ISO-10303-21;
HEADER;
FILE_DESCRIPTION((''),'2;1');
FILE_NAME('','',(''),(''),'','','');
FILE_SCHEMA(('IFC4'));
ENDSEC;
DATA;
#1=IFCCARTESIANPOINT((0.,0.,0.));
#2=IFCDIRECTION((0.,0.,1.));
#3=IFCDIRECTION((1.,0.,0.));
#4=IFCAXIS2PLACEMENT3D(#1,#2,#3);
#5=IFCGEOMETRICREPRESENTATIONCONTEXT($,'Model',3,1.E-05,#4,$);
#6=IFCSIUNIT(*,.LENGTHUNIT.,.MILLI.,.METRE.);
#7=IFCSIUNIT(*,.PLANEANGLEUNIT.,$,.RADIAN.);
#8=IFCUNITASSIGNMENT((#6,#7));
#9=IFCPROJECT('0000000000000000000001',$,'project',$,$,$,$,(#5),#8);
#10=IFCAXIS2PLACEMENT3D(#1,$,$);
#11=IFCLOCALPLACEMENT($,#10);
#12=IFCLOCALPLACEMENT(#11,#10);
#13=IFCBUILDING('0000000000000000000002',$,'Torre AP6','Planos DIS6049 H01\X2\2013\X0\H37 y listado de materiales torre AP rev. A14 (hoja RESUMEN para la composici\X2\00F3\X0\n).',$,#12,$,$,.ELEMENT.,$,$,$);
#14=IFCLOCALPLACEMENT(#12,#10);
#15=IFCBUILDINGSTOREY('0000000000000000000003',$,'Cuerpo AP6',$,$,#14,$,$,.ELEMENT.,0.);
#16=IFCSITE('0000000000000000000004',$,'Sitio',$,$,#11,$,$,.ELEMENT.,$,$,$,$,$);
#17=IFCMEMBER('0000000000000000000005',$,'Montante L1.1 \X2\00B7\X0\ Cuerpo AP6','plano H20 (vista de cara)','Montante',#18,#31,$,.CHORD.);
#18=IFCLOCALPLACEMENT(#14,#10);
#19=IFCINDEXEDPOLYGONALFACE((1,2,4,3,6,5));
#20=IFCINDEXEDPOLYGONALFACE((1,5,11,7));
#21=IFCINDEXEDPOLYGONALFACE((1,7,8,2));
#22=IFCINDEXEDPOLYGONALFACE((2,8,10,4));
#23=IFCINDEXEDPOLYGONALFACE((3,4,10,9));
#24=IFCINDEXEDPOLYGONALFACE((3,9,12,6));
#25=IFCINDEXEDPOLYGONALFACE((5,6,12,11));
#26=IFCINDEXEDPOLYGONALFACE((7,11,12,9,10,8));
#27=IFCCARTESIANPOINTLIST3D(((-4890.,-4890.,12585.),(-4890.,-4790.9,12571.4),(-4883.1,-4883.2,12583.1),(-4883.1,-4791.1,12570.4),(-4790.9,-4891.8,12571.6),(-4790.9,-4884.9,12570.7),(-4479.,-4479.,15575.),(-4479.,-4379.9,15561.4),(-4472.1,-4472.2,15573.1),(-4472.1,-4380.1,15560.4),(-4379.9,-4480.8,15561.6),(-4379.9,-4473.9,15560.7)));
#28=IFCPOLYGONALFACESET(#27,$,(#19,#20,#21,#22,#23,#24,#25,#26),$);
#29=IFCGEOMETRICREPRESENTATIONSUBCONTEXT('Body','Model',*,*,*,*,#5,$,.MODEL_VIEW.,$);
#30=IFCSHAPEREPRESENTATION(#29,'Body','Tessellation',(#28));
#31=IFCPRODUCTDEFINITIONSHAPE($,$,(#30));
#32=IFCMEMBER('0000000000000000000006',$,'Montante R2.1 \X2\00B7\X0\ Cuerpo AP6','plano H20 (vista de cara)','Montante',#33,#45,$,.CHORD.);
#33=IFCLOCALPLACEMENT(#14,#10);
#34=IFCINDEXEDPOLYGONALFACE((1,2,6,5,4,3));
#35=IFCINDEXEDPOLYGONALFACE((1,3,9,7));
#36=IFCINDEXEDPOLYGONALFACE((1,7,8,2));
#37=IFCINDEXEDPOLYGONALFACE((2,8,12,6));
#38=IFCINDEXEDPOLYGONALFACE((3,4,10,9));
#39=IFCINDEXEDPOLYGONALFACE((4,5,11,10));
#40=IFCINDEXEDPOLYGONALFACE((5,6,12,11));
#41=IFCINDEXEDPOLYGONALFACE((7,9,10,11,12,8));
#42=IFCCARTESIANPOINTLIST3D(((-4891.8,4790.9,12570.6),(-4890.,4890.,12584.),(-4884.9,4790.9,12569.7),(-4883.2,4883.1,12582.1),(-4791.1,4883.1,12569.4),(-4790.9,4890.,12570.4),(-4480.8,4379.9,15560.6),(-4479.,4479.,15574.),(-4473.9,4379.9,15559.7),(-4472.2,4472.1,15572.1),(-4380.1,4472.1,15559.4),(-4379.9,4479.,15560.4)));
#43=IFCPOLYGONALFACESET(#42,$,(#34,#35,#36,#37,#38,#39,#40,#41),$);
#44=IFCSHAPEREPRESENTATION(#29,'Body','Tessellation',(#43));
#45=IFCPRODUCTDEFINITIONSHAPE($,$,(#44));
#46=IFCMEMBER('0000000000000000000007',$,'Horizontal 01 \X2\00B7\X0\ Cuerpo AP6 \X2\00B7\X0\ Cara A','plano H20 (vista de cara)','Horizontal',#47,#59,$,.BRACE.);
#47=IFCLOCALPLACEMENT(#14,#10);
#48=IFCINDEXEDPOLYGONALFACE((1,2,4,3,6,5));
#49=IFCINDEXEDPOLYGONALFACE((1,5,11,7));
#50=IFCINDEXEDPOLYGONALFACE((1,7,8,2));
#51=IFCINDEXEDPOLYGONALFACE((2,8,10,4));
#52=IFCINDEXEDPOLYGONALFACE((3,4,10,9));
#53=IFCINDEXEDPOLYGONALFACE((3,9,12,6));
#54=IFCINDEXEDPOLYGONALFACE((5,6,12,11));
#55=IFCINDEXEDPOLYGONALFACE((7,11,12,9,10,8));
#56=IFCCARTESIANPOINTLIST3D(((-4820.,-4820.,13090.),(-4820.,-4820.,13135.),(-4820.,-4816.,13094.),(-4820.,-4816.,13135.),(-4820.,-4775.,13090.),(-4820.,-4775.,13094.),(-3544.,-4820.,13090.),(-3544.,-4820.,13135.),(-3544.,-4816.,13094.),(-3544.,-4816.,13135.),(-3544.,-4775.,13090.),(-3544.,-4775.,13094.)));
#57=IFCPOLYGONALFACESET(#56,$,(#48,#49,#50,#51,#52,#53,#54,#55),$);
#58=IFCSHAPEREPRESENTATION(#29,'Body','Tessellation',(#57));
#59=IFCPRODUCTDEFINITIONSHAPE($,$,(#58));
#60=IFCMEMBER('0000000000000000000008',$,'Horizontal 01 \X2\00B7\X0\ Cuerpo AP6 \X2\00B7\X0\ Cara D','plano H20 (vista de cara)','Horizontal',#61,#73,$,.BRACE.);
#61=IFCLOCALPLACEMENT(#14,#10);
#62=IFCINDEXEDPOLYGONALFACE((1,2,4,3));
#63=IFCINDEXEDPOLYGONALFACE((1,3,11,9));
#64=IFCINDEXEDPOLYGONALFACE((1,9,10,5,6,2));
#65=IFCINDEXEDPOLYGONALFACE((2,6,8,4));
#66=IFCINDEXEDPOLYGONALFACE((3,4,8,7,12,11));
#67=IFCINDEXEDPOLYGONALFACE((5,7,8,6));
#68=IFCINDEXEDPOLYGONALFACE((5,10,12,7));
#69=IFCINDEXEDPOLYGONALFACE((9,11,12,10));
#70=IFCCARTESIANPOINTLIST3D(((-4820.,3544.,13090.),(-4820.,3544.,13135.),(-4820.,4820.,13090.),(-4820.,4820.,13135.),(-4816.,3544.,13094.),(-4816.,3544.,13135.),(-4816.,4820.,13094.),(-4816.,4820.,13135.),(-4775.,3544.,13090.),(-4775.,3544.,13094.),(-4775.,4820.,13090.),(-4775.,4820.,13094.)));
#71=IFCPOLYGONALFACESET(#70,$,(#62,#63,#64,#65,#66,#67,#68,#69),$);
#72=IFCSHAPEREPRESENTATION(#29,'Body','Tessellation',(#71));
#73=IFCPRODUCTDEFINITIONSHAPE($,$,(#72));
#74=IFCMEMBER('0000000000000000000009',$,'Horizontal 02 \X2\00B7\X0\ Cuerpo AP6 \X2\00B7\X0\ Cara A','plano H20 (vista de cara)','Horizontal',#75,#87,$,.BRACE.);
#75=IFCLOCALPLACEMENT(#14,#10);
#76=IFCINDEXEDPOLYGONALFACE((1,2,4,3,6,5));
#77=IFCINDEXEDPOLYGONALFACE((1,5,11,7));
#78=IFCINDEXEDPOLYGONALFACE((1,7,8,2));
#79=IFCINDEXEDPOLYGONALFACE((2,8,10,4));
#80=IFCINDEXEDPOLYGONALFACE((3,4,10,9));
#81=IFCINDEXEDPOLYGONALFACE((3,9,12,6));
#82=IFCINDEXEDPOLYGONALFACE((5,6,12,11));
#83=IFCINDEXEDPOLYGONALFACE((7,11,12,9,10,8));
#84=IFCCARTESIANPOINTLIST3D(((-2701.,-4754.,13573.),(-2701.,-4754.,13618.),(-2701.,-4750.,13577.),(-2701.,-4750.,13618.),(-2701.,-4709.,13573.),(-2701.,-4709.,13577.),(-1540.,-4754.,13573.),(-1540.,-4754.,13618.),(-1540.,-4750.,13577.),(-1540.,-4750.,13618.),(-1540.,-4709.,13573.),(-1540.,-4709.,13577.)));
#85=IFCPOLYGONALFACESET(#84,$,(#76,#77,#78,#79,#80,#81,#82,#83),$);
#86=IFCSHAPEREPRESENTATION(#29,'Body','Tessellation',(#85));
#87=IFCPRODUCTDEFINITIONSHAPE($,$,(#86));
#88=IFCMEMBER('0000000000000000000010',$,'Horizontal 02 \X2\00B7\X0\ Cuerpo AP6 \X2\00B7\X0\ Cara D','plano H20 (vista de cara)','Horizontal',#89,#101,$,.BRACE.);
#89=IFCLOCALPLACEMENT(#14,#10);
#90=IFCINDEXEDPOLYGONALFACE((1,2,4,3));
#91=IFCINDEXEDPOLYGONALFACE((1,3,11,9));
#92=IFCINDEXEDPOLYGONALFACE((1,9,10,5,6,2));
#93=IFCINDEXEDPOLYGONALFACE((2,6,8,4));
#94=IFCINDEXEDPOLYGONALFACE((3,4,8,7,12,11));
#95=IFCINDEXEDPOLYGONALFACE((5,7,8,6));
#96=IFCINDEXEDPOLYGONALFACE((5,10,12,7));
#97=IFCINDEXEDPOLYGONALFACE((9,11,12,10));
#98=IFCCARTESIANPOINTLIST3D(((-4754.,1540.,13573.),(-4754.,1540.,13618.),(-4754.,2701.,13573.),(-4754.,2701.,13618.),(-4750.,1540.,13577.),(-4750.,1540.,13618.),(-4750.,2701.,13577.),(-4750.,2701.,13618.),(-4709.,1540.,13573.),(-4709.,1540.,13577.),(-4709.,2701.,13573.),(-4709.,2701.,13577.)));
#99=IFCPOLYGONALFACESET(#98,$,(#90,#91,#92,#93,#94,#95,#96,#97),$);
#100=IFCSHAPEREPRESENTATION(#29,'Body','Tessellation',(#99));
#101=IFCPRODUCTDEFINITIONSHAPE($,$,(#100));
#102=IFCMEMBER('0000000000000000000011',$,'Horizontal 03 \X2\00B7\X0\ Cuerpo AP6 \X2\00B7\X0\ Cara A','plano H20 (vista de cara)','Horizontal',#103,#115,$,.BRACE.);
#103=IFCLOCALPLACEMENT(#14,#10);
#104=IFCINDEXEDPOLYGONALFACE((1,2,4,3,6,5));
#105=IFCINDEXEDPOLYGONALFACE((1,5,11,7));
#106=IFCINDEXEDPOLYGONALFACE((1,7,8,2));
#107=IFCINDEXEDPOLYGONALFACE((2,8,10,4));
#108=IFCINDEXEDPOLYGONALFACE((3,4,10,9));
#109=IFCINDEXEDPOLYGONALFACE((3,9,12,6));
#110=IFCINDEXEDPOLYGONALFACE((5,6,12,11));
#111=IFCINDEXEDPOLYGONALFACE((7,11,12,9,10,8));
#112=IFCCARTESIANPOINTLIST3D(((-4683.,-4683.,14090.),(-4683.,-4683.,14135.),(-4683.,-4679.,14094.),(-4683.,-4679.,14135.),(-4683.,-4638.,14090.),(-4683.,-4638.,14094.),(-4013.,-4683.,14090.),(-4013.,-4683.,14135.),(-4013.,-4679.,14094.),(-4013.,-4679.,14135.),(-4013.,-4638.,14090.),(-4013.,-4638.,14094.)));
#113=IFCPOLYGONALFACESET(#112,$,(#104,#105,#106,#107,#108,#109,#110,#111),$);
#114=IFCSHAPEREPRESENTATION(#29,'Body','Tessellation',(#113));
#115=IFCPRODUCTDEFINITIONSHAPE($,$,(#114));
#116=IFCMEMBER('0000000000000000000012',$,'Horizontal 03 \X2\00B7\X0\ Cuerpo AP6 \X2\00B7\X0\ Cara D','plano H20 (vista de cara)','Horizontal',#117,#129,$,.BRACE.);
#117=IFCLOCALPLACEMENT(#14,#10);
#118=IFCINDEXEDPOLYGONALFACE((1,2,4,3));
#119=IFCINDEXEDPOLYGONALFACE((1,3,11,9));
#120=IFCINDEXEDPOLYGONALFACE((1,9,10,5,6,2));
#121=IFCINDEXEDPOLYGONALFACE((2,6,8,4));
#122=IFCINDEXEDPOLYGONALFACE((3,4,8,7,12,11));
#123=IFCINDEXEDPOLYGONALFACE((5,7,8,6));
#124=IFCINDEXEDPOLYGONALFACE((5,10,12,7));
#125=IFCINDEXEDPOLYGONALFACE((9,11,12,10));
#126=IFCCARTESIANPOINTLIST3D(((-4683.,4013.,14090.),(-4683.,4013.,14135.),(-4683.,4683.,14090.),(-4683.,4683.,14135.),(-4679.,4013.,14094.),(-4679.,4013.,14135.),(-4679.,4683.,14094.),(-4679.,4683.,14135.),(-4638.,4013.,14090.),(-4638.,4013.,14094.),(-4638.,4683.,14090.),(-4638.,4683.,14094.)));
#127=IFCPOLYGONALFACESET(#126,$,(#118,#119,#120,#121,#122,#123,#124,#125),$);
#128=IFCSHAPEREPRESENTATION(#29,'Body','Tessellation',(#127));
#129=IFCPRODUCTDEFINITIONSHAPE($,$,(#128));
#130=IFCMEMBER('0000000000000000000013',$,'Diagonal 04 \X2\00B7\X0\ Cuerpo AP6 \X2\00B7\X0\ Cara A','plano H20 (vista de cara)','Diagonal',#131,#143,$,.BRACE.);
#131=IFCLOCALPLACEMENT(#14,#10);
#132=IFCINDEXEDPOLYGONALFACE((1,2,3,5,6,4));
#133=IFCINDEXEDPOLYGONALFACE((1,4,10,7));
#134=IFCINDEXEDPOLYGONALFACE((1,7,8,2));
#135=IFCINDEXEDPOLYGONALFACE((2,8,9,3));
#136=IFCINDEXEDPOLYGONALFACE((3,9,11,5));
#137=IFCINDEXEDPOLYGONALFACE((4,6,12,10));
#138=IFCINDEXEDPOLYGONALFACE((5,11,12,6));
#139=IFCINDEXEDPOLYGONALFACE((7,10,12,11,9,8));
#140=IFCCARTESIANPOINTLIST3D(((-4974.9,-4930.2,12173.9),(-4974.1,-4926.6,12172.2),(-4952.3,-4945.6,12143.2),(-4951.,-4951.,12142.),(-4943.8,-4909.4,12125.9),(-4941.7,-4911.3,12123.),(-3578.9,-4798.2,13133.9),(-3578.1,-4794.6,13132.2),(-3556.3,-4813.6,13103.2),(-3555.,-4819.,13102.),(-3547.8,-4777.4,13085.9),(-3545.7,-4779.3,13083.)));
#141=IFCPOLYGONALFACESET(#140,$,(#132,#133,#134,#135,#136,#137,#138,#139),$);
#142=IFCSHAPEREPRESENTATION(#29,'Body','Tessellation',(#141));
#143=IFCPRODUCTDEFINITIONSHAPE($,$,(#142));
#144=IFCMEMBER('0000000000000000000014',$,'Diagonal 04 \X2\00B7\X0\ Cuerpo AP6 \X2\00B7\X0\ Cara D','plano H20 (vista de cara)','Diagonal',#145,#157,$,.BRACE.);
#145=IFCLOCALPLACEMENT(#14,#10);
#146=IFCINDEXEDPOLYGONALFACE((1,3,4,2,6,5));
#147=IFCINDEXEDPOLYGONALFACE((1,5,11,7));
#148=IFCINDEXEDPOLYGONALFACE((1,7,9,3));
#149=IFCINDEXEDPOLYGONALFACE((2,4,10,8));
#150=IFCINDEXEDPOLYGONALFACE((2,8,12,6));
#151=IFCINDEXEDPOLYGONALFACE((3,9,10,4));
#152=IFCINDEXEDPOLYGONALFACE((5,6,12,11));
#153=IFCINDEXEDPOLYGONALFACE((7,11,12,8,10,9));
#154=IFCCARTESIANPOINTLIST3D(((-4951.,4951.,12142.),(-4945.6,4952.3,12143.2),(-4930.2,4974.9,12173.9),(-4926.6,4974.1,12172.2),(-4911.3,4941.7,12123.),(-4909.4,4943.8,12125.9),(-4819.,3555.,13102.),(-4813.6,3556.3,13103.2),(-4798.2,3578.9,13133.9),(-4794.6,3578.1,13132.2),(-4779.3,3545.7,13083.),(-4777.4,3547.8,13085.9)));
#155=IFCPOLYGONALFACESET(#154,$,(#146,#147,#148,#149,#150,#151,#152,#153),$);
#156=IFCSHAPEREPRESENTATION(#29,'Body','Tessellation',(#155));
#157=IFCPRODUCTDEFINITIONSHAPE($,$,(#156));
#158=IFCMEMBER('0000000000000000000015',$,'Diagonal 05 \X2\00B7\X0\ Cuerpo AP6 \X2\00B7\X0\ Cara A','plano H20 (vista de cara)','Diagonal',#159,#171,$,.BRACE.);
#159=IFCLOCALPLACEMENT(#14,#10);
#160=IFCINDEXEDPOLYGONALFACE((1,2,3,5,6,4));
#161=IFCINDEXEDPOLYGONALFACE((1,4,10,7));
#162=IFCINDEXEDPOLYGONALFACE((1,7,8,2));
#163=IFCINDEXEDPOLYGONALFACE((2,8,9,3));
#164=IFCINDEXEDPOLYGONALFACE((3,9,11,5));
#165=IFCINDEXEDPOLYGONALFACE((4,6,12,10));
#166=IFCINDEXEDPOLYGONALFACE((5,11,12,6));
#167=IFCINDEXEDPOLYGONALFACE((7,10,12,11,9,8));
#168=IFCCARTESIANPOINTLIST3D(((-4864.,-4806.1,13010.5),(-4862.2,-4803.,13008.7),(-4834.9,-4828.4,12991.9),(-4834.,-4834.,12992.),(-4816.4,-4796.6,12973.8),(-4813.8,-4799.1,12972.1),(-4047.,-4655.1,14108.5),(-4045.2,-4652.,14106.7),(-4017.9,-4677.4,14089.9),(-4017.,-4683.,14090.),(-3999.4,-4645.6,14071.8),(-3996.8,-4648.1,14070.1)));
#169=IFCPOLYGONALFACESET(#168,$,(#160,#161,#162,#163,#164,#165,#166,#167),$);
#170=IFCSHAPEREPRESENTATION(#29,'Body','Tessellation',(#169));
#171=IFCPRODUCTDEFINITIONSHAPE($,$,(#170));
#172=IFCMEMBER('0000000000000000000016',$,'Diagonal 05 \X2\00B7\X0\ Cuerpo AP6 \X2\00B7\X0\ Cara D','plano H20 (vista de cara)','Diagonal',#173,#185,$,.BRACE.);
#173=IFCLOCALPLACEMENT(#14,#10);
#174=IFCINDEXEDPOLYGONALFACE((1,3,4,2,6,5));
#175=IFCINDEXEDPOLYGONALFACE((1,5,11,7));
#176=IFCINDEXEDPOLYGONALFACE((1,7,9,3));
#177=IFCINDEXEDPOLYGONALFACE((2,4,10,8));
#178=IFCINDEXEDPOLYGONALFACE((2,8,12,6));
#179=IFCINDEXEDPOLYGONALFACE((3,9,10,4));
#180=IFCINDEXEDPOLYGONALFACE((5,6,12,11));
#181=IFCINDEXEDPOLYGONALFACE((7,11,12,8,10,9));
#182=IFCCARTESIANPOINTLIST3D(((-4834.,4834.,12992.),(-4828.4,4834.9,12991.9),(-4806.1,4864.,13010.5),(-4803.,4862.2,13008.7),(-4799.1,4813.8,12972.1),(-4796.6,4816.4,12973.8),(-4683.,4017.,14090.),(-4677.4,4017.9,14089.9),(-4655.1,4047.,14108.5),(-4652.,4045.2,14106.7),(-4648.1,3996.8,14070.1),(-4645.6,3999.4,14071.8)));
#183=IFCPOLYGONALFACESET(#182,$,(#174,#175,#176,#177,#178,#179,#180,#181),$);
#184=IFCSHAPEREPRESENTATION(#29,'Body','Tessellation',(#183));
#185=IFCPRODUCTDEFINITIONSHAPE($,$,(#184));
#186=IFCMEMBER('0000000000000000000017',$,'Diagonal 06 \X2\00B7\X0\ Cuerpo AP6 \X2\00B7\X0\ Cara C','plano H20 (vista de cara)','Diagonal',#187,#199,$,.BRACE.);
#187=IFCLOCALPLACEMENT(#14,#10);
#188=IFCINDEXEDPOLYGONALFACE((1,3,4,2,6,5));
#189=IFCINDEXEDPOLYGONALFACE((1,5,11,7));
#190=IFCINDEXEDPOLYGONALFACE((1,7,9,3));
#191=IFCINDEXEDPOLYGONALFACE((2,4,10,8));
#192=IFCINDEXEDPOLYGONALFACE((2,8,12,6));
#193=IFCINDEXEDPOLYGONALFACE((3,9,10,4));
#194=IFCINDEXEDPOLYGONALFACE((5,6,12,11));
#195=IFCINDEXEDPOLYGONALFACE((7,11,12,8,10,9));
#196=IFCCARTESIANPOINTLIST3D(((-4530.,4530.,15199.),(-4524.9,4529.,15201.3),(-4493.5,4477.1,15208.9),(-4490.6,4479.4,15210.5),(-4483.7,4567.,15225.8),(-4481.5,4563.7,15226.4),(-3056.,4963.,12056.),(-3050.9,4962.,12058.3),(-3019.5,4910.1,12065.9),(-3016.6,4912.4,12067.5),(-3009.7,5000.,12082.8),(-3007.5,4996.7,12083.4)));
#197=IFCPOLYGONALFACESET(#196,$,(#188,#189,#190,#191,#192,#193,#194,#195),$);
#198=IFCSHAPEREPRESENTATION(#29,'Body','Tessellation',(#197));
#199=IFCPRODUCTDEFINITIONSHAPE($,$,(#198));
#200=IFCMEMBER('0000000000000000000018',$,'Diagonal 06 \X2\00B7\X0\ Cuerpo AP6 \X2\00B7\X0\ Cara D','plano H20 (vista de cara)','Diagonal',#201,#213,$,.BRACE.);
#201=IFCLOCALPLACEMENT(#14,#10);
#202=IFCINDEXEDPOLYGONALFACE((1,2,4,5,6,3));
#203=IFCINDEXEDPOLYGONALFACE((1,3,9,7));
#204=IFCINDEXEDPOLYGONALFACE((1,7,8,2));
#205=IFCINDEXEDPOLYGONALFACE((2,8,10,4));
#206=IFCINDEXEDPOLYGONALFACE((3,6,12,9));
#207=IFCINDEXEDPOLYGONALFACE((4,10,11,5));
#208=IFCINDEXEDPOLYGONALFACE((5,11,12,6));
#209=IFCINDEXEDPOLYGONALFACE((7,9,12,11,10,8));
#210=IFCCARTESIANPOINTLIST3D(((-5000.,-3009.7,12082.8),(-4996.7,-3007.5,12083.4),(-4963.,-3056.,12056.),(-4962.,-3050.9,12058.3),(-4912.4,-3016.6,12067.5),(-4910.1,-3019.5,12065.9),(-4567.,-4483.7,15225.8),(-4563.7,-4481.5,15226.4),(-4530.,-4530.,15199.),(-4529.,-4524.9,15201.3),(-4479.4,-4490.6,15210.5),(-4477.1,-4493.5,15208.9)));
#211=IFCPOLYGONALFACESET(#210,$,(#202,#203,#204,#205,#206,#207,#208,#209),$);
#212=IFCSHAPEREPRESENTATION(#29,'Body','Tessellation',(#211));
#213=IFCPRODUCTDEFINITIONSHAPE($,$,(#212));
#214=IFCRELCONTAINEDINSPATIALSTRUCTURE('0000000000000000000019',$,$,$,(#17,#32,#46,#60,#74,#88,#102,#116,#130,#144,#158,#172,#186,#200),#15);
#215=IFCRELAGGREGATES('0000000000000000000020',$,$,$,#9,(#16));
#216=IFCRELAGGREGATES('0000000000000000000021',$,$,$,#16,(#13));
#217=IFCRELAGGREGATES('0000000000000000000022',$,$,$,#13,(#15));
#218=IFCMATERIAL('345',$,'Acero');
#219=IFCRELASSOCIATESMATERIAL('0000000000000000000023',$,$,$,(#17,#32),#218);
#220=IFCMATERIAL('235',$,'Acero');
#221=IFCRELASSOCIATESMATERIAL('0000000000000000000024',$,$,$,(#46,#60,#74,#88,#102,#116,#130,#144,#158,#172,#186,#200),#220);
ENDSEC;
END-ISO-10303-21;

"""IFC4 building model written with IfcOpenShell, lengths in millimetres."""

from ifc_helpers import new_model, si_unit, frame, frame_2d, origin, origin_with_axes, place, context, subcontext, project, spatial, l_section, extrude, material, element, save


model = new_model("IFC4")

# Units and contexts
model_context = context("Model", 3, precision=1e-05, world=origin_with_axes())
body_context = subcontext(model_context, "Body", "Model", "MODEL_VIEW")
ifc_project = project(units=[si_unit("LENGTHUNIT", "METRE", prefix="MILLI"), si_unit("PLANEANGLEUNIT", "RADIAN")], contexts=[model_context])

# Site, building, storey
site_placement = place(None, origin())
site = spatial("IfcSite", under=ifc_project, at=site_placement, Name="Sitio", CompositionType="ELEMENT")
building_placement = place(site_placement, origin())
building = spatial("IfcBuilding", under=site, at=building_placement, Name="Torre AP6", Description="Planos DIS6049 H01–H37 y listado de materiales torre AP rev. A14 (hoja RESUMEN para la composición).", CompositionType="ELEMENT")
storey_placement = place(building_placement, origin())
storey = spatial("IfcBuildingStorey", under=building, at=storey_placement, Name="Cuerpo AP6", CompositionType="ELEMENT", Elevation=0.0)

# Members
ifc_material_1 = material(Name="345", Category="Acero")
for number, where, z_axis, x_axis, name in (
    (1, (-4890.0, -4890.0, 12585.0), (0.134932, 0.134932, 0.981624), (0.990855, -0.018375, -0.133675), "Montante L1.1 · Cuerpo AP6"),
    (2, (-4890.0, 4890.0, 12584.0), (0.134932, -0.134932, 0.981624), (-0.018375, -0.990855, -0.133675), "Montante R2.1 · Cuerpo AP6"),
):
    element("IfcMember", number, at=place(storey_placement, frame(where, z_axis=z_axis, x_axis=x_axis)), inside=storey, material=ifc_material_1, Name=name, Description="plano H20 (vista de cara)", ObjectType="Montante", PredefinedType="CHORD", context=body_context, shape_type="SweptSolid", body=[
        extrude(l_section(Depth=100.0, Width=100.0, Thickness=7.0, at=frame_2d((50.0, 50.0))), None, (0.0, 0.0, 1.0), 3046.0),
    ])
ifc_material_2 = material(Name="235", Category="Acero")
for number, where, z_axis, x_axis, name in (
    (3, (-4820.0, -4820.0, 13090.0), (1.0, 0.0, 0.0), (0.0, 1.0, 0.0), "Horizontal 01 · Cuerpo AP6 · Cara A"),
    (4, (-4820.0, 4820.0, 13090.0), (0.0, -1.0, 0.0), (1.0, 0.0, 0.0), "Horizontal 01 · Cuerpo AP6 · Cara D"),
):
    element("IfcMember", number, at=place(storey_placement, frame(where, z_axis=z_axis, x_axis=x_axis)), inside=storey, material=ifc_material_2, Name=name, Description="plano H20 (vista de cara)", ObjectType="Horizontal", PredefinedType="BRACE", context=body_context, shape_type="SweptSolid", body=[
        extrude(l_section(Depth=45.0, Width=45.0, Thickness=4.0, at=frame_2d((22.5, 22.5))), None, (0.0, 0.0, 1.0), 1276.0),
    ])
for number, where, z_axis, x_axis, name in (
    (5, (-2701.0, -4754.0, 13573.0), (1.0, 0.0, 0.0), (0.0, 1.0, 0.0), "Horizontal 02 · Cuerpo AP6 · Cara A"),
    (6, (-4754.0, 2701.0, 13573.0), (0.0, -1.0, 0.0), (1.0, 0.0, 0.0), "Horizontal 02 · Cuerpo AP6 · Cara D"),
):
    element("IfcMember", number, at=place(storey_placement, frame(where, z_axis=z_axis, x_axis=x_axis)), inside=storey, material=ifc_material_2, Name=name, Description="plano H20 (vista de cara)", ObjectType="Horizontal", PredefinedType="BRACE", context=body_context, shape_type="SweptSolid", body=[
        extrude(l_section(Depth=45.0, Width=45.0, Thickness=4.0, at=frame_2d((22.5, 22.5))), None, (0.0, 0.0, 1.0), 1161.0),
    ])
for number, where, z_axis, x_axis, name in (
    (7, (-4683.0, -4683.0, 14090.0), (1.0, 0.0, 0.0), (0.0, 1.0, 0.0), "Horizontal 03 · Cuerpo AP6 · Cara A"),
    (8, (-4683.0, 4683.0, 14090.0), (0.0, -1.0, 0.0), (1.0, 0.0, 0.0), "Horizontal 03 · Cuerpo AP6 · Cara D"),
):
    element("IfcMember", number, at=place(storey_placement, frame(where, z_axis=z_axis, x_axis=x_axis)), inside=storey, material=ifc_material_2, Name=name, Description="plano H20 (vista de cara)", ObjectType="Horizontal", PredefinedType="BRACE", context=body_context, shape_type="SweptSolid", body=[
        extrude(l_section(Depth=45.0, Width=45.0, Thickness=4.0, at=frame_2d((22.5, 22.5))), None, (0.0, 0.0, 1.0), 670.0),
    ])
for number, where, z_axis, x_axis, name in (
    (9, (-4951.0, -4951.0, 12142.0), (0.821484, 0.077676, 0.564917), (0.206349, 0.883046, -0.421485), "Diagonal 04 · Cuerpo AP6 · Cara A"),
    (10, (-4951.0, 4951.0, 12142.0), (0.077676, -0.821484, 0.564917), (0.883046, -0.206349, -0.421485), "Diagonal 04 · Cuerpo AP6 · Cara D"),
):
    element("IfcMember", number, at=place(storey_placement, frame(where, z_axis=z_axis, x_axis=x_axis)), inside=storey, material=ifc_material_2, Name=name, Description="plano H20 (vista de cara)", ObjectType="Diagonal", PredefinedType="BRACE", context=body_context, shape_type="SweptSolid", body=[
        extrude(l_section(Depth=45.0, Width=45.0, Thickness=4.0, at=frame_2d((22.5, 22.5))), None, (0.0, 0.0, 1.0), 1699.4),
    ])
for number, where, z_axis, x_axis, name in (
    (11, (-4834.0, -4834.0, 12992.0), (0.593356, 0.109665, 0.797435), (0.44991, 0.776296, -0.441527), "Diagonal 05 · Cuerpo AP6 · Cara A"),
    (12, (-4834.0, 4834.0, 12992.0), (0.109665, -0.593356, 0.797435), (0.776296, -0.44991, -0.441527), "Diagonal 05 · Cuerpo AP6 · Cara D"),
):
    element("IfcMember", number, at=place(storey_placement, frame(where, z_axis=z_axis, x_axis=x_axis)), inside=storey, material=ifc_material_2, Name=name, Description="plano H20 (vista de cara)", ObjectType="Diagonal", PredefinedType="BRACE", context=body_context, shape_type="SweptSolid", body=[
        extrude(l_section(Depth=45.0, Width=45.0, Thickness=4.0, at=frame_2d((22.5, 22.5))), None, (0.0, 0.0, 1.0), 1376.9),
    ])
for number, where, z_axis, x_axis, name in (
    (13, (-3056.0, 4963.0, 12056.0), (-0.421339, -0.123772, 0.898418), (0.562018, -0.813122, 0.151554), "Diagonal 06 · Cuerpo AP6 · Cara C"),
    (14, (-4963.0, -3056.0, 12056.0), (0.123772, -0.421339, 0.898418), (0.813122, 0.562018, 0.151554), "Diagonal 06 · Cuerpo AP6 · Cara D"),
):
    element("IfcMember", number, at=place(storey_placement, frame(where, z_axis=z_axis, x_axis=x_axis)), inside=storey, material=ifc_material_2, Name=name, Description="plano H20 (vista de cara)", ObjectType="Diagonal", PredefinedType="BRACE", context=body_context, shape_type="SweptSolid", body=[
        extrude(l_section(Depth=65.0, Width=65.0, Thickness=4.0, at=frame_2d((32.5, 32.5))), None, (0.0, 0.0, 1.0), 3498.4),
    ])

save(model, "model.ifc")
